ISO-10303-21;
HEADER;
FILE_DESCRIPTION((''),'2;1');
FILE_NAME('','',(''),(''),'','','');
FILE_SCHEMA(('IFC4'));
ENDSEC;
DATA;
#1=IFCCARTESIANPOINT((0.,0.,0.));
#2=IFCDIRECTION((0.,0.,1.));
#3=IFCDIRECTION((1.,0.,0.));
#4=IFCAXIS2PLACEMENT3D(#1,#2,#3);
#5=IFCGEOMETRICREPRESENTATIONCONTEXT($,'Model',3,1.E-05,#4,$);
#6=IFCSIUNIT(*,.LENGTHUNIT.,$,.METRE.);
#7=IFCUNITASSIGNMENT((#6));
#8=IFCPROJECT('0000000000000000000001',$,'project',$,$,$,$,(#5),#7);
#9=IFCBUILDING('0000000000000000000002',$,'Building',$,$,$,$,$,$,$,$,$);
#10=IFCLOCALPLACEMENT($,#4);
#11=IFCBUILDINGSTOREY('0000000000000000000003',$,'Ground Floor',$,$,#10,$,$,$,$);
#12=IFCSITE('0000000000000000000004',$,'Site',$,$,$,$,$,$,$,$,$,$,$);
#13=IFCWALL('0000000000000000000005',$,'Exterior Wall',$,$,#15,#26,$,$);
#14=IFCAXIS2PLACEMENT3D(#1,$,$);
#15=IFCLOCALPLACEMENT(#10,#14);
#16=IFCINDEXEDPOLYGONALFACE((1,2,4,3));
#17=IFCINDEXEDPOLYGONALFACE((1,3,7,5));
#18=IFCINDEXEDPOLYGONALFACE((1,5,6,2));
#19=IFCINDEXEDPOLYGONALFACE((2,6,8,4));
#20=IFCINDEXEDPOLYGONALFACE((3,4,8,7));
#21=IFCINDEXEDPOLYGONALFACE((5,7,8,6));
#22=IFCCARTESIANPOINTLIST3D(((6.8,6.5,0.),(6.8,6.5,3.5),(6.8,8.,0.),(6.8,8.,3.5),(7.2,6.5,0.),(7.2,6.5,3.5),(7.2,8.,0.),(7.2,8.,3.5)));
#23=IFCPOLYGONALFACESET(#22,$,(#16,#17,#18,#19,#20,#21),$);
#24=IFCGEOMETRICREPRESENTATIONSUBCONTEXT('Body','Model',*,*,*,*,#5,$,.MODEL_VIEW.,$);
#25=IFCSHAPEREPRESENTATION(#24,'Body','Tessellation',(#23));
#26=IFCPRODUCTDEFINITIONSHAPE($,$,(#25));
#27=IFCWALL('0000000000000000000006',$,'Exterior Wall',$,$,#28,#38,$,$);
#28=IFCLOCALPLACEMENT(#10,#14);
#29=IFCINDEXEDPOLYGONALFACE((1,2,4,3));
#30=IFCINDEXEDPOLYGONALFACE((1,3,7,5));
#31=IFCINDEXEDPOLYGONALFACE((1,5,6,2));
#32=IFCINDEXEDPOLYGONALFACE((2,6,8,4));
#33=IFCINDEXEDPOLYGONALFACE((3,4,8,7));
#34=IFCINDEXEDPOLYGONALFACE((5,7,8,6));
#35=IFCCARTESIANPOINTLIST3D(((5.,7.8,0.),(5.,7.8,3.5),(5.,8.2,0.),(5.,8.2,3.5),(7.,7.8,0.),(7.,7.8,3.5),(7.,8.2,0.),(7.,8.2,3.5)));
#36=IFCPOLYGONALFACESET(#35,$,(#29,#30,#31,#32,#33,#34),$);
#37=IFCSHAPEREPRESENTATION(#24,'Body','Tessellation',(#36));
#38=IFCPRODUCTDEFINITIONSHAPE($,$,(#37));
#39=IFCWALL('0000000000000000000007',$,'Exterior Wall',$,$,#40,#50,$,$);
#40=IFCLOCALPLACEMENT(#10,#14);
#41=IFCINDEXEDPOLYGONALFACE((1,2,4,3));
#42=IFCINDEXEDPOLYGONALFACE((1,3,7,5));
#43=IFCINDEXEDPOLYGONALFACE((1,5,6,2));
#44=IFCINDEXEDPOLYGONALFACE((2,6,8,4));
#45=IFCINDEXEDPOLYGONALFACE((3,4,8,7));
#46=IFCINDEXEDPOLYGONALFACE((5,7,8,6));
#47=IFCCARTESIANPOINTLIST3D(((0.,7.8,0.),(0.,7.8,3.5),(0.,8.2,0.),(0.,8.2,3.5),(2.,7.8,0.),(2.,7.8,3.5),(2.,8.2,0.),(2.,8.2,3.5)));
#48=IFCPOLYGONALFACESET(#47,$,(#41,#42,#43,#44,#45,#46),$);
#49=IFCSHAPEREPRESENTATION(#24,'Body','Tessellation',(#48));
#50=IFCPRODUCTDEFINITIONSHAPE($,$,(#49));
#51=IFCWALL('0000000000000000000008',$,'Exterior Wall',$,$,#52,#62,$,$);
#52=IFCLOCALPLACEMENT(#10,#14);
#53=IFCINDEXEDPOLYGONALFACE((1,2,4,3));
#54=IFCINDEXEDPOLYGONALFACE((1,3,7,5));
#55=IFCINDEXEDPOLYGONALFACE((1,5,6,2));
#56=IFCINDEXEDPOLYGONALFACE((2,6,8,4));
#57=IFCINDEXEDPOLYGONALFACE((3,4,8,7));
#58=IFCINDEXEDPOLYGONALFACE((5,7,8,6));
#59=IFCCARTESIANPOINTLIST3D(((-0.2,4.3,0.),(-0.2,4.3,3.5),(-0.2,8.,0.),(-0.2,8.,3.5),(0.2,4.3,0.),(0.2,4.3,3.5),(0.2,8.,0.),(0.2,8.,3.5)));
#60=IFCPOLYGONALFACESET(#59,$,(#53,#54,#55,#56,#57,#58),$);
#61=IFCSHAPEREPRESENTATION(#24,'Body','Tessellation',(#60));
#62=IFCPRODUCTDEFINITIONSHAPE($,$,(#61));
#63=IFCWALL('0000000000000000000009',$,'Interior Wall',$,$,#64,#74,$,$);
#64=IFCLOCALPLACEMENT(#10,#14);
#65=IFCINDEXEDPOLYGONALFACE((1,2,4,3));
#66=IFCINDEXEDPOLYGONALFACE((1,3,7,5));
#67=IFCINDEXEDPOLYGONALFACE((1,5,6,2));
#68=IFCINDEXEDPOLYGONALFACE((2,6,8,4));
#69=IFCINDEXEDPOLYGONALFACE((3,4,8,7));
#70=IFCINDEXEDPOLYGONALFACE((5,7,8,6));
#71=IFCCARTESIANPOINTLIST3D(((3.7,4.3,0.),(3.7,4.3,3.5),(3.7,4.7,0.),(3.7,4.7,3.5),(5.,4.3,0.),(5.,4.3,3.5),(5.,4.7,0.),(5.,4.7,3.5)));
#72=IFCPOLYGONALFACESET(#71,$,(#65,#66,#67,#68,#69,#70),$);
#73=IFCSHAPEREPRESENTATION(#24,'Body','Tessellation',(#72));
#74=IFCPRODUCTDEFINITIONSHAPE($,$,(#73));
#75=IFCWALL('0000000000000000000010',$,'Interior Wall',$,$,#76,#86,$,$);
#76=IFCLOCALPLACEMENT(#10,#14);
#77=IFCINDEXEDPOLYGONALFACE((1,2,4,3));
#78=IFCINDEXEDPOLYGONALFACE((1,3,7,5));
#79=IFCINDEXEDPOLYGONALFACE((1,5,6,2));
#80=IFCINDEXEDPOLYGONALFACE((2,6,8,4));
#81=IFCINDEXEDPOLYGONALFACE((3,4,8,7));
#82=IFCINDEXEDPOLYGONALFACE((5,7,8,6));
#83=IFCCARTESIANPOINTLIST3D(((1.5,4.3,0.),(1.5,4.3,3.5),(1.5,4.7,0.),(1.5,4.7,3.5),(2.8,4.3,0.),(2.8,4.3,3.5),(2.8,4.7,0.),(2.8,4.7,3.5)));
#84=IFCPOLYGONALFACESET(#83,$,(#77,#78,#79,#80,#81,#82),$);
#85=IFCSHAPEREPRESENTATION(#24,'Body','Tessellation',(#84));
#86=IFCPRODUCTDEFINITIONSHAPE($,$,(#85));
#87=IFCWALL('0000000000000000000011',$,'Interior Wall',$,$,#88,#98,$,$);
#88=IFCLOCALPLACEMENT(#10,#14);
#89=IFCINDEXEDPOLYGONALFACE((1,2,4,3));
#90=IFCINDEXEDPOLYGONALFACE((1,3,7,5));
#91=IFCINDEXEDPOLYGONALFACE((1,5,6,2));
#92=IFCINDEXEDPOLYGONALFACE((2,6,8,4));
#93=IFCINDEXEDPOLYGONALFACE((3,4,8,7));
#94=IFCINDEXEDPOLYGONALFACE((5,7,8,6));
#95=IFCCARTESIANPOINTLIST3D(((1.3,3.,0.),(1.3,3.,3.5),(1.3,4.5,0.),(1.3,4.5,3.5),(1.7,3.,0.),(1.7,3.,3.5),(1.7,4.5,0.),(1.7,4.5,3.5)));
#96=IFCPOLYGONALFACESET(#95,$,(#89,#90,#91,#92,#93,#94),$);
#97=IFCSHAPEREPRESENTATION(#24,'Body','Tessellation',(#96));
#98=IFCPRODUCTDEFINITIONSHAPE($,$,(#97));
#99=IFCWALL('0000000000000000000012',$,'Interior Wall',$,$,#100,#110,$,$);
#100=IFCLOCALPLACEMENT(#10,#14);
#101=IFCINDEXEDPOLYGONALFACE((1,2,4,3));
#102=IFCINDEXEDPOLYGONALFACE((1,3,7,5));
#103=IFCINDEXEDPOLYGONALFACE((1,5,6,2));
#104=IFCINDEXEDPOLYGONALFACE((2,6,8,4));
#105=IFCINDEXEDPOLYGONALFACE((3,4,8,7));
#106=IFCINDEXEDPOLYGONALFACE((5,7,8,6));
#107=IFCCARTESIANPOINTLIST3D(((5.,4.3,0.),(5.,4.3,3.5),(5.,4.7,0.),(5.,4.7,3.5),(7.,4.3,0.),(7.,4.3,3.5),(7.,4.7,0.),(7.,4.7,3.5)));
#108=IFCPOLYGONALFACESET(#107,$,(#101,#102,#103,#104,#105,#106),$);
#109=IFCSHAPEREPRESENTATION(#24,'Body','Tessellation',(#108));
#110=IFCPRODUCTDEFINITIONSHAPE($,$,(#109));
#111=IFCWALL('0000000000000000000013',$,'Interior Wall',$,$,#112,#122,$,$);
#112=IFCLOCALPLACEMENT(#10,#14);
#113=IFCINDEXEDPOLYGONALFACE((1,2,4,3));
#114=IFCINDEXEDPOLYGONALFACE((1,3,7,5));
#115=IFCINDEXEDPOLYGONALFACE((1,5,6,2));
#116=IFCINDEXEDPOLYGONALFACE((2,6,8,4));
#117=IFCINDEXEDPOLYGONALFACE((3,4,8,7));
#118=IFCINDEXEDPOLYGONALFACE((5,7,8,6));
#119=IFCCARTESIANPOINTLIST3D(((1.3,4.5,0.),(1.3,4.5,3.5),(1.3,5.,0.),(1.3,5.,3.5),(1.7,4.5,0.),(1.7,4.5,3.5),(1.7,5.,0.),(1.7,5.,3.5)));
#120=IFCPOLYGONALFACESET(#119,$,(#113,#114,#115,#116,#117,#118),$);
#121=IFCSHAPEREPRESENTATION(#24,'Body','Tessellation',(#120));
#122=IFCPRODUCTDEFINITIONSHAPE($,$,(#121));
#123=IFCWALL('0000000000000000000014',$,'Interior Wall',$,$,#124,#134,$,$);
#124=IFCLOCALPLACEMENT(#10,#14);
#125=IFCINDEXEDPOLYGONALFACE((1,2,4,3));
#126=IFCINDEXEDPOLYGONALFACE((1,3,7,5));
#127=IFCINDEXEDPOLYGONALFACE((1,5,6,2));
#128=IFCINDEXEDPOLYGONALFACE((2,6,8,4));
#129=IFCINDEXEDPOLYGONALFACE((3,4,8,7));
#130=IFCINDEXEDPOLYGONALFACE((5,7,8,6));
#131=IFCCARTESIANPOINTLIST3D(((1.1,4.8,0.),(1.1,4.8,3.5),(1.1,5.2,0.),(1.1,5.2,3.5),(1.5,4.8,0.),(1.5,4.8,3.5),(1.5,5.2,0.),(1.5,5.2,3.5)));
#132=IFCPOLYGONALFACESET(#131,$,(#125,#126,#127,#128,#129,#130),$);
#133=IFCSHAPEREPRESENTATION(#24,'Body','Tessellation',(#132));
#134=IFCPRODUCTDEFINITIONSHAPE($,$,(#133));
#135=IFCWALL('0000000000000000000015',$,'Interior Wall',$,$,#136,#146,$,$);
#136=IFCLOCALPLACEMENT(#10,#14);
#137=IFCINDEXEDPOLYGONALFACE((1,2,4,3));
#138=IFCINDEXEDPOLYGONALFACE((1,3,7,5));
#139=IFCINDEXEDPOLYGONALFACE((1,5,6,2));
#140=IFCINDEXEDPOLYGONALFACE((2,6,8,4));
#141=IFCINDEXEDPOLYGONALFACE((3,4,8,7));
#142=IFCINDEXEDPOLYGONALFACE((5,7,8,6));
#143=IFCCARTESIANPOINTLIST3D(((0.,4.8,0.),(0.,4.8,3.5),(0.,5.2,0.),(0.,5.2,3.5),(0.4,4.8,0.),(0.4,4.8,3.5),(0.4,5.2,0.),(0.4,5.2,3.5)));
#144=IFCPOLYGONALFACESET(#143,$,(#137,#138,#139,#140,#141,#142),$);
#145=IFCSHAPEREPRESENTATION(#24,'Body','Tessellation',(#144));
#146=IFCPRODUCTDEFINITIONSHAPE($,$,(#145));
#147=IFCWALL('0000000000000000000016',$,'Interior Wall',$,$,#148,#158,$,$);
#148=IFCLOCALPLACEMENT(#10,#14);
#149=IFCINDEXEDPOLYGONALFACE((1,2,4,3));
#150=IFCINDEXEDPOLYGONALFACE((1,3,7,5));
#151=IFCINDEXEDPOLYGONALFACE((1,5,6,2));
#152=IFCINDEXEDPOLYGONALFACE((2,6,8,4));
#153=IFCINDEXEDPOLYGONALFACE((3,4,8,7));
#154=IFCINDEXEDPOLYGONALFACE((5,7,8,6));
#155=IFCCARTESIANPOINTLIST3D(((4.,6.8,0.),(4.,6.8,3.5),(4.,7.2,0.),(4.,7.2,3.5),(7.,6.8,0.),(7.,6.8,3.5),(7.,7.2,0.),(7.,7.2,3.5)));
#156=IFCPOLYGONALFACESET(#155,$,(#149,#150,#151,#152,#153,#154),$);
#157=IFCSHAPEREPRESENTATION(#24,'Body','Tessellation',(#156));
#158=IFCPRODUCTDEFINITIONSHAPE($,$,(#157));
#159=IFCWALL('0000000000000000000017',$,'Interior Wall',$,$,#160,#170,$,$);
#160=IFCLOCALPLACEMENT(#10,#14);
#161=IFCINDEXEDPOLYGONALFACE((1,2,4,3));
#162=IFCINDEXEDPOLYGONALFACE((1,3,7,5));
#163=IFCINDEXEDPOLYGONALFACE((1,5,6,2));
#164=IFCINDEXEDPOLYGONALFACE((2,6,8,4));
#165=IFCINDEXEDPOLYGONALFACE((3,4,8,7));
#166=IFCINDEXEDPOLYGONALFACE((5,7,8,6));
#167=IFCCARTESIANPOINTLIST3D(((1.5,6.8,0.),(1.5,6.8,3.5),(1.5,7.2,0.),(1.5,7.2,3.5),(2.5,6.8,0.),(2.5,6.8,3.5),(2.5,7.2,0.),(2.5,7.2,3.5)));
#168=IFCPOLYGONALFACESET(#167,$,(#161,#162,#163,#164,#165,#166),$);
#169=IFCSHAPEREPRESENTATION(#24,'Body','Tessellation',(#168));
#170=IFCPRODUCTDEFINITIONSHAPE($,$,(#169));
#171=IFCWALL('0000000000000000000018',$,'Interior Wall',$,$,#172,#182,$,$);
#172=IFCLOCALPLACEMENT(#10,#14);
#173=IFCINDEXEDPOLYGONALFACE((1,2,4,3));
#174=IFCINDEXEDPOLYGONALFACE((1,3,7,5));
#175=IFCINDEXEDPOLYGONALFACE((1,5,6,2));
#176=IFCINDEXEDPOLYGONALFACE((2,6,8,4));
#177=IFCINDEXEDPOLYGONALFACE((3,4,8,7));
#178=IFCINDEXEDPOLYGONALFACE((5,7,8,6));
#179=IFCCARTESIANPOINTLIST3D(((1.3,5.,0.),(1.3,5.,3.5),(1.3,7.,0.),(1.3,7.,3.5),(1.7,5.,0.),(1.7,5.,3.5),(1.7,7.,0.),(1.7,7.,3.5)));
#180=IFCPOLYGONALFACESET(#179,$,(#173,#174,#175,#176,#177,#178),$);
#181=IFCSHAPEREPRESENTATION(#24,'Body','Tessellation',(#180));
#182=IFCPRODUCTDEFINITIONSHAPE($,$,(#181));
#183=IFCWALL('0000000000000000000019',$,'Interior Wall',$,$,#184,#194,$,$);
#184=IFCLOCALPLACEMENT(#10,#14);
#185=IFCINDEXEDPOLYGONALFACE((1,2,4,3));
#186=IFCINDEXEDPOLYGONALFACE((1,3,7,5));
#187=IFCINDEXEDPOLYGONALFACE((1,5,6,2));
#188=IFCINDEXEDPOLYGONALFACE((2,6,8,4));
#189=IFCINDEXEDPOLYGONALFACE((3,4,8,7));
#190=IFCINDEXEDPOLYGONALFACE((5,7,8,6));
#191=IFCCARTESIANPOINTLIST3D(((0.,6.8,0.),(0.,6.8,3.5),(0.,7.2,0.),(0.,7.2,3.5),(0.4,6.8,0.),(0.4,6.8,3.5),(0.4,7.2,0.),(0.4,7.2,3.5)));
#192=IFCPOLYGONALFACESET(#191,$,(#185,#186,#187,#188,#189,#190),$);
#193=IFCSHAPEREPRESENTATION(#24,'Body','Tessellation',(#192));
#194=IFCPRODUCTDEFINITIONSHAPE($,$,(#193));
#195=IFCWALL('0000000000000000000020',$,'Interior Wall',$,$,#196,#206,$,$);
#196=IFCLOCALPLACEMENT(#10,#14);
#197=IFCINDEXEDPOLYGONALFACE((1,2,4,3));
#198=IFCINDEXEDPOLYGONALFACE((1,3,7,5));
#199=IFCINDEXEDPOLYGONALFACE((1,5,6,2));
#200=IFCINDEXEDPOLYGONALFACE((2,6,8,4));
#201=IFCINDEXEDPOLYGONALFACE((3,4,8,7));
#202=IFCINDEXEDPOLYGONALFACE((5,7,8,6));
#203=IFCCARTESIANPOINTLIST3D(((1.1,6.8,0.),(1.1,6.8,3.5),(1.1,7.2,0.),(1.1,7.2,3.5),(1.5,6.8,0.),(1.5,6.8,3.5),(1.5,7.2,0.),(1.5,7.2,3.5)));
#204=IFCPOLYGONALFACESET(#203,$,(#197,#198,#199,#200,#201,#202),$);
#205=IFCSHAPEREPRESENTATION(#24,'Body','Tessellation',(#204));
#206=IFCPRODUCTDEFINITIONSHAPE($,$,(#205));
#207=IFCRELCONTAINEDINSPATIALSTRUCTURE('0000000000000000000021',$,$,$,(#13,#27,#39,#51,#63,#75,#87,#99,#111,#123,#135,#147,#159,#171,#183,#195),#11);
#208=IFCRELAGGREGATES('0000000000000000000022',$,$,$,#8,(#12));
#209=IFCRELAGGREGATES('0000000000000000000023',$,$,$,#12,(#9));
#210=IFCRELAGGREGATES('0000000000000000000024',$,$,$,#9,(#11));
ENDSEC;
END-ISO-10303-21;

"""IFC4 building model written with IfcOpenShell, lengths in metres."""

from ifc_helpers import new_model, si_unit, frame, origin_with_axes, place, context, subcontext, project, spatial, indexed_curve, outline, extrude, element, save


model = new_model("IFC4")

# Units and contexts
model_context = context("Model", 3, precision=1e-05, world=origin_with_axes())
body_context = subcontext(model_context, "Body", "Model", "MODEL_VIEW")
ifc_project = project(units=[si_unit("LENGTHUNIT", "METRE")], contexts=[model_context])

# Site, building, storey
site = spatial("IfcSite", under=ifc_project, Name="Site")
building = spatial("IfcBuilding", under=site, Name="Building")
storey_placement = place(None, origin_with_axes())
storey = spatial("IfcBuildingStorey", under=building, at=storey_placement, Name="Ground Floor")

# Walls
wall_1_placement = place(storey_placement, frame((7.0, 6.5, 0.0), z_axis=(0.0, 0.0, 1.0), x_axis=(0.0, 1.0, 0.0)))
element("IfcWall", 1, at=wall_1_placement, inside=storey, Name="Exterior Wall", context=body_context, shape_type="SweptSolid", body=[
    extrude(outline(indexed_curve([(0.0, 0.0), (0.0, 0.4), (1.5, 0.4), (1.5, 0.0), (0.0, 0.0)], self_intersect=False)), frame((0.0, -0.2, 0.0), z_axis=(0.0, 0.0, 1.0), x_axis=(1.0, 0.0, 0.0)), (0.0, 0.0, 1.0), 3.5),
])
for number, where, z_axis, x_axis, name in (
    (2, (7.0, 8.0, 0.0), (0.0, 0.0, 1.0), (-1.0, 0.0, 0.0), "Exterior Wall"),
    (3, (2.0, 8.0, 0.0), (0.0, 0.0, 1.0), (-1.0, 0.0, 0.0), "Exterior Wall"),
):
    element("IfcWall", number, at=place(storey_placement, frame(where, z_axis=z_axis, x_axis=x_axis)), inside=storey, Name=name, context=body_context, shape_type="SweptSolid", body=[
        extrude(outline(indexed_curve([(0.0, 0.0), (0.0, 0.4), (2.0, 0.4), (2.0, 0.0), (0.0, 0.0)], self_intersect=False)), frame((0.0, -0.2, 0.0), z_axis=(0.0, 0.0, 1.0), x_axis=(1.0, 0.0, 0.0)), (0.0, 0.0, 1.0), 3.5),
    ])
wall_2_placement = place(storey_placement, frame((0.0, 8.0, 0.0), z_axis=(0.0, 0.0, 1.0), x_axis=(0.0, -1.0, 0.0)))
element("IfcWall", 4, at=wall_2_placement, inside=storey, Name="Exterior Wall", context=body_context, shape_type="SweptSolid", body=[
    extrude(outline(indexed_curve([(0.0, 0.0), (0.0, 0.4), (3.7, 0.4), (3.7, 0.0), (0.0, 0.0)], self_intersect=False)), frame((0.0, -0.2, 0.0), z_axis=(0.0, 0.0, 1.0), x_axis=(1.0, 0.0, 0.0)), (0.0, 0.0, 1.0), 3.5),
])
for number, where, z_axis, x_axis, name in (
    (5, (5.0, 4.5, 0.0), (0.0, 0.0, 1.0), (-1.0, 0.0, 0.0), "Interior Wall"),
    (6, (2.8, 4.5, 0.0), (0.0, 0.0, 1.0), (-1.0, 0.0, 0.0), "Interior Wall"),
):
    element("IfcWall", number, at=place(storey_placement, frame(where, z_axis=z_axis, x_axis=x_axis)), inside=storey, Name=name, context=body_context, shape_type="SweptSolid", body=[
        extrude(outline(indexed_curve([(0.0, 0.0), (0.0, 0.4), (1.3, 0.4), (1.3, 0.0), (0.0, 0.0)], self_intersect=False)), frame((0.0, -0.2, 0.0), z_axis=(0.0, 0.0, 1.0), x_axis=(1.0, 0.0, 0.0)), (0.0, 0.0, 1.0), 3.5),
    ])
wall_3_placement = place(storey_placement, frame((1.5, 4.5, 0.0), z_axis=(0.0, 0.0, 1.0), x_axis=(0.0, -1.0, 0.0)))
element("IfcWall", 7, at=wall_3_placement, inside=storey, Name="Interior Wall", context=body_context, shape_type="SweptSolid", body=[
    extrude(outline(indexed_curve([(0.0, 0.0), (0.0, 0.4), (1.5, 0.4), (1.5, 0.0), (0.0, 0.0)], self_intersect=False)), frame((0.0, -0.2, 0.0), z_axis=(0.0, 0.0, 1.0), x_axis=(1.0, 0.0, 0.0)), (0.0, 0.0, 1.0), 3.5),
])
wall_4_placement = place(storey_placement, frame((7.0, 4.5, 0.0), z_axis=(0.0, 0.0, 1.0), x_axis=(-1.0, 0.0, 0.0)))
element("IfcWall", 8, at=wall_4_placement, inside=storey, Name="Interior Wall", context=body_context, shape_type="SweptSolid", body=[
    extrude(outline(indexed_curve([(0.0, 0.0), (0.0, 0.4), (2.0, 0.4), (2.0, 0.0), (0.0, 0.0)], self_intersect=False)), frame((0.0, -0.2, 0.0), z_axis=(0.0, 0.0, 1.0), x_axis=(1.0, 0.0, 0.0)), (0.0, 0.0, 1.0), 3.5),
])
wall_5_placement = place(storey_placement, frame((1.5, 4.5, 0.0), z_axis=(0.0, 0.0, 1.0), x_axis=(0.0, 1.0, 0.0)))
element("IfcWall", 9, at=wall_5_placement, inside=storey, Name="Interior Wall", context=body_context, shape_type="SweptSolid", body=[
    extrude(outline(indexed_curve([(0.0, 0.0), (0.0, 0.4), (0.5, 0.4), (0.5, 0.0), (0.0, 0.0)], self_intersect=False)), frame((0.0, -0.2, 0.0), z_axis=(0.0, 0.0, 1.0), x_axis=(1.0, 0.0, 0.0)), (0.0, 0.0, 1.0), 3.5),
])
for number, where, z_axis, x_axis, name in (
    (10, (1.5, 5.0, 0.0), (0.0, 0.0, 1.0), (-1.0, 0.0, 0.0), "Interior Wall"),
    (11, (0.4, 5.0, 0.0), (0.0, 0.0, 1.0), (-1.0, 0.0, 0.0), "Interior Wall"),
):
    element("IfcWall", number, at=place(storey_placement, frame(where, z_axis=z_axis, x_axis=x_axis)), inside=storey, Name=name, context=body_context, shape_type="SweptSolid", body=[
        extrude(outline(indexed_curve([(0.0, 0.0), (0.0, 0.4), (0.4, 0.4), (0.4, 0.0), (0.0, 0.0)], self_intersect=False)), frame((0.0, -0.2, 0.0), z_axis=(0.0, 0.0, 1.0), x_axis=(1.0, 0.0, 0.0)), (0.0, 0.0, 1.0), 3.5),
    ])
wall_6_placement = place(storey_placement, frame((7.0, 7.0, 0.0), z_axis=(0.0, 0.0, 1.0), x_axis=(-1.0, 0.0, 0.0)))
element("IfcWall", 12, at=wall_6_placement, inside=storey, Name="Interior Wall", context=body_context, shape_type="SweptSolid", body=[
    extrude(outline(indexed_curve([(0.0, 0.0), (0.0, 0.4), (3.0, 0.4), (3.0, 0.0), (0.0, 0.0)], self_intersect=False)), frame((0.0, -0.2, 0.0), z_axis=(0.0, 0.0, 1.0), x_axis=(1.0, 0.0, 0.0)), (0.0, 0.0, 1.0), 3.5),
])
wall_7_placement = place(storey_placement, frame((2.5, 7.0, 0.0), z_axis=(0.0, 0.0, 1.0), x_axis=(-1.0, 0.0, 0.0)))
element("IfcWall", 13, at=wall_7_placement, inside=storey, Name="Interior Wall", context=body_context, shape_type="SweptSolid", body=[
    extrude(outline(indexed_curve([(0.0, 0.0), (0.0, 0.4), (1.0, 0.4), (1.0, 0.0), (0.0, 0.0)], self_intersect=False)), frame((0.0, -0.2, 0.0), z_axis=(0.0, 0.0, 1.0), x_axis=(1.0, 0.0, 0.0)), (0.0, 0.0, 1.0), 3.5),
])
wall_8_placement = place(storey_placement, frame((1.5, 7.0, 0.0), z_axis=(0.0, 0.0, 1.0), x_axis=(0.0, -1.0, 0.0)))
element("IfcWall", 14, at=wall_8_placement, inside=storey, Name="Interior Wall", context=body_context, shape_type="SweptSolid", body=[
    extrude(outline(indexed_curve([(0.0, 0.0), (0.0, 0.4), (2.0, 0.4), (2.0, 0.0), (0.0, 0.0)], self_intersect=False)), frame((0.0, -0.2, 0.0), z_axis=(0.0, 0.0, 1.0), x_axis=(1.0, 0.0, 0.0)), (0.0, 0.0, 1.0), 3.5),
])
wall_9_placement = place(storey_placement, frame((0.0, 7.0, 0.0), z_axis=(0.0, 0.0, 1.0), x_axis=(1.0, 0.0, 0.0)))
element("IfcWall", 15, at=wall_9_placement, inside=storey, Name="Interior Wall", context=body_context, shape_type="SweptSolid", body=[
    extrude(outline(indexed_curve([(0.0, 0.0), (0.0, 0.4), (0.4, 0.4), (0.4, 0.0), (0.0, 0.0)], self_intersect=False)), frame((0.0, -0.2, 0.0), z_axis=(0.0, 0.0, 1.0), x_axis=(1.0, 0.0, 0.0)), (0.0, 0.0, 1.0), 3.5),
])
wall_10_placement = place(storey_placement, frame((1.1, 7.0, 0.0), z_axis=(0.0, 0.0, 1.0), x_axis=(1.0, 0.0, 0.0)))
element("IfcWall", 16, at=wall_10_placement, inside=storey, Name="Interior Wall", context=body_context, shape_type="SweptSolid", body=[
    extrude(outline(indexed_curve([(0.0, 0.0), (0.0, 0.4), (0.4, 0.4), (0.4, 0.0), (0.0, 0.0)], self_intersect=False)), frame((0.0, -0.2, 0.0), z_axis=(0.0, 0.0, 1.0), x_axis=(1.0, 0.0, 0.0)), (0.0, 0.0, 1.0), 3.5),
])

save(model, "model.ifc")
